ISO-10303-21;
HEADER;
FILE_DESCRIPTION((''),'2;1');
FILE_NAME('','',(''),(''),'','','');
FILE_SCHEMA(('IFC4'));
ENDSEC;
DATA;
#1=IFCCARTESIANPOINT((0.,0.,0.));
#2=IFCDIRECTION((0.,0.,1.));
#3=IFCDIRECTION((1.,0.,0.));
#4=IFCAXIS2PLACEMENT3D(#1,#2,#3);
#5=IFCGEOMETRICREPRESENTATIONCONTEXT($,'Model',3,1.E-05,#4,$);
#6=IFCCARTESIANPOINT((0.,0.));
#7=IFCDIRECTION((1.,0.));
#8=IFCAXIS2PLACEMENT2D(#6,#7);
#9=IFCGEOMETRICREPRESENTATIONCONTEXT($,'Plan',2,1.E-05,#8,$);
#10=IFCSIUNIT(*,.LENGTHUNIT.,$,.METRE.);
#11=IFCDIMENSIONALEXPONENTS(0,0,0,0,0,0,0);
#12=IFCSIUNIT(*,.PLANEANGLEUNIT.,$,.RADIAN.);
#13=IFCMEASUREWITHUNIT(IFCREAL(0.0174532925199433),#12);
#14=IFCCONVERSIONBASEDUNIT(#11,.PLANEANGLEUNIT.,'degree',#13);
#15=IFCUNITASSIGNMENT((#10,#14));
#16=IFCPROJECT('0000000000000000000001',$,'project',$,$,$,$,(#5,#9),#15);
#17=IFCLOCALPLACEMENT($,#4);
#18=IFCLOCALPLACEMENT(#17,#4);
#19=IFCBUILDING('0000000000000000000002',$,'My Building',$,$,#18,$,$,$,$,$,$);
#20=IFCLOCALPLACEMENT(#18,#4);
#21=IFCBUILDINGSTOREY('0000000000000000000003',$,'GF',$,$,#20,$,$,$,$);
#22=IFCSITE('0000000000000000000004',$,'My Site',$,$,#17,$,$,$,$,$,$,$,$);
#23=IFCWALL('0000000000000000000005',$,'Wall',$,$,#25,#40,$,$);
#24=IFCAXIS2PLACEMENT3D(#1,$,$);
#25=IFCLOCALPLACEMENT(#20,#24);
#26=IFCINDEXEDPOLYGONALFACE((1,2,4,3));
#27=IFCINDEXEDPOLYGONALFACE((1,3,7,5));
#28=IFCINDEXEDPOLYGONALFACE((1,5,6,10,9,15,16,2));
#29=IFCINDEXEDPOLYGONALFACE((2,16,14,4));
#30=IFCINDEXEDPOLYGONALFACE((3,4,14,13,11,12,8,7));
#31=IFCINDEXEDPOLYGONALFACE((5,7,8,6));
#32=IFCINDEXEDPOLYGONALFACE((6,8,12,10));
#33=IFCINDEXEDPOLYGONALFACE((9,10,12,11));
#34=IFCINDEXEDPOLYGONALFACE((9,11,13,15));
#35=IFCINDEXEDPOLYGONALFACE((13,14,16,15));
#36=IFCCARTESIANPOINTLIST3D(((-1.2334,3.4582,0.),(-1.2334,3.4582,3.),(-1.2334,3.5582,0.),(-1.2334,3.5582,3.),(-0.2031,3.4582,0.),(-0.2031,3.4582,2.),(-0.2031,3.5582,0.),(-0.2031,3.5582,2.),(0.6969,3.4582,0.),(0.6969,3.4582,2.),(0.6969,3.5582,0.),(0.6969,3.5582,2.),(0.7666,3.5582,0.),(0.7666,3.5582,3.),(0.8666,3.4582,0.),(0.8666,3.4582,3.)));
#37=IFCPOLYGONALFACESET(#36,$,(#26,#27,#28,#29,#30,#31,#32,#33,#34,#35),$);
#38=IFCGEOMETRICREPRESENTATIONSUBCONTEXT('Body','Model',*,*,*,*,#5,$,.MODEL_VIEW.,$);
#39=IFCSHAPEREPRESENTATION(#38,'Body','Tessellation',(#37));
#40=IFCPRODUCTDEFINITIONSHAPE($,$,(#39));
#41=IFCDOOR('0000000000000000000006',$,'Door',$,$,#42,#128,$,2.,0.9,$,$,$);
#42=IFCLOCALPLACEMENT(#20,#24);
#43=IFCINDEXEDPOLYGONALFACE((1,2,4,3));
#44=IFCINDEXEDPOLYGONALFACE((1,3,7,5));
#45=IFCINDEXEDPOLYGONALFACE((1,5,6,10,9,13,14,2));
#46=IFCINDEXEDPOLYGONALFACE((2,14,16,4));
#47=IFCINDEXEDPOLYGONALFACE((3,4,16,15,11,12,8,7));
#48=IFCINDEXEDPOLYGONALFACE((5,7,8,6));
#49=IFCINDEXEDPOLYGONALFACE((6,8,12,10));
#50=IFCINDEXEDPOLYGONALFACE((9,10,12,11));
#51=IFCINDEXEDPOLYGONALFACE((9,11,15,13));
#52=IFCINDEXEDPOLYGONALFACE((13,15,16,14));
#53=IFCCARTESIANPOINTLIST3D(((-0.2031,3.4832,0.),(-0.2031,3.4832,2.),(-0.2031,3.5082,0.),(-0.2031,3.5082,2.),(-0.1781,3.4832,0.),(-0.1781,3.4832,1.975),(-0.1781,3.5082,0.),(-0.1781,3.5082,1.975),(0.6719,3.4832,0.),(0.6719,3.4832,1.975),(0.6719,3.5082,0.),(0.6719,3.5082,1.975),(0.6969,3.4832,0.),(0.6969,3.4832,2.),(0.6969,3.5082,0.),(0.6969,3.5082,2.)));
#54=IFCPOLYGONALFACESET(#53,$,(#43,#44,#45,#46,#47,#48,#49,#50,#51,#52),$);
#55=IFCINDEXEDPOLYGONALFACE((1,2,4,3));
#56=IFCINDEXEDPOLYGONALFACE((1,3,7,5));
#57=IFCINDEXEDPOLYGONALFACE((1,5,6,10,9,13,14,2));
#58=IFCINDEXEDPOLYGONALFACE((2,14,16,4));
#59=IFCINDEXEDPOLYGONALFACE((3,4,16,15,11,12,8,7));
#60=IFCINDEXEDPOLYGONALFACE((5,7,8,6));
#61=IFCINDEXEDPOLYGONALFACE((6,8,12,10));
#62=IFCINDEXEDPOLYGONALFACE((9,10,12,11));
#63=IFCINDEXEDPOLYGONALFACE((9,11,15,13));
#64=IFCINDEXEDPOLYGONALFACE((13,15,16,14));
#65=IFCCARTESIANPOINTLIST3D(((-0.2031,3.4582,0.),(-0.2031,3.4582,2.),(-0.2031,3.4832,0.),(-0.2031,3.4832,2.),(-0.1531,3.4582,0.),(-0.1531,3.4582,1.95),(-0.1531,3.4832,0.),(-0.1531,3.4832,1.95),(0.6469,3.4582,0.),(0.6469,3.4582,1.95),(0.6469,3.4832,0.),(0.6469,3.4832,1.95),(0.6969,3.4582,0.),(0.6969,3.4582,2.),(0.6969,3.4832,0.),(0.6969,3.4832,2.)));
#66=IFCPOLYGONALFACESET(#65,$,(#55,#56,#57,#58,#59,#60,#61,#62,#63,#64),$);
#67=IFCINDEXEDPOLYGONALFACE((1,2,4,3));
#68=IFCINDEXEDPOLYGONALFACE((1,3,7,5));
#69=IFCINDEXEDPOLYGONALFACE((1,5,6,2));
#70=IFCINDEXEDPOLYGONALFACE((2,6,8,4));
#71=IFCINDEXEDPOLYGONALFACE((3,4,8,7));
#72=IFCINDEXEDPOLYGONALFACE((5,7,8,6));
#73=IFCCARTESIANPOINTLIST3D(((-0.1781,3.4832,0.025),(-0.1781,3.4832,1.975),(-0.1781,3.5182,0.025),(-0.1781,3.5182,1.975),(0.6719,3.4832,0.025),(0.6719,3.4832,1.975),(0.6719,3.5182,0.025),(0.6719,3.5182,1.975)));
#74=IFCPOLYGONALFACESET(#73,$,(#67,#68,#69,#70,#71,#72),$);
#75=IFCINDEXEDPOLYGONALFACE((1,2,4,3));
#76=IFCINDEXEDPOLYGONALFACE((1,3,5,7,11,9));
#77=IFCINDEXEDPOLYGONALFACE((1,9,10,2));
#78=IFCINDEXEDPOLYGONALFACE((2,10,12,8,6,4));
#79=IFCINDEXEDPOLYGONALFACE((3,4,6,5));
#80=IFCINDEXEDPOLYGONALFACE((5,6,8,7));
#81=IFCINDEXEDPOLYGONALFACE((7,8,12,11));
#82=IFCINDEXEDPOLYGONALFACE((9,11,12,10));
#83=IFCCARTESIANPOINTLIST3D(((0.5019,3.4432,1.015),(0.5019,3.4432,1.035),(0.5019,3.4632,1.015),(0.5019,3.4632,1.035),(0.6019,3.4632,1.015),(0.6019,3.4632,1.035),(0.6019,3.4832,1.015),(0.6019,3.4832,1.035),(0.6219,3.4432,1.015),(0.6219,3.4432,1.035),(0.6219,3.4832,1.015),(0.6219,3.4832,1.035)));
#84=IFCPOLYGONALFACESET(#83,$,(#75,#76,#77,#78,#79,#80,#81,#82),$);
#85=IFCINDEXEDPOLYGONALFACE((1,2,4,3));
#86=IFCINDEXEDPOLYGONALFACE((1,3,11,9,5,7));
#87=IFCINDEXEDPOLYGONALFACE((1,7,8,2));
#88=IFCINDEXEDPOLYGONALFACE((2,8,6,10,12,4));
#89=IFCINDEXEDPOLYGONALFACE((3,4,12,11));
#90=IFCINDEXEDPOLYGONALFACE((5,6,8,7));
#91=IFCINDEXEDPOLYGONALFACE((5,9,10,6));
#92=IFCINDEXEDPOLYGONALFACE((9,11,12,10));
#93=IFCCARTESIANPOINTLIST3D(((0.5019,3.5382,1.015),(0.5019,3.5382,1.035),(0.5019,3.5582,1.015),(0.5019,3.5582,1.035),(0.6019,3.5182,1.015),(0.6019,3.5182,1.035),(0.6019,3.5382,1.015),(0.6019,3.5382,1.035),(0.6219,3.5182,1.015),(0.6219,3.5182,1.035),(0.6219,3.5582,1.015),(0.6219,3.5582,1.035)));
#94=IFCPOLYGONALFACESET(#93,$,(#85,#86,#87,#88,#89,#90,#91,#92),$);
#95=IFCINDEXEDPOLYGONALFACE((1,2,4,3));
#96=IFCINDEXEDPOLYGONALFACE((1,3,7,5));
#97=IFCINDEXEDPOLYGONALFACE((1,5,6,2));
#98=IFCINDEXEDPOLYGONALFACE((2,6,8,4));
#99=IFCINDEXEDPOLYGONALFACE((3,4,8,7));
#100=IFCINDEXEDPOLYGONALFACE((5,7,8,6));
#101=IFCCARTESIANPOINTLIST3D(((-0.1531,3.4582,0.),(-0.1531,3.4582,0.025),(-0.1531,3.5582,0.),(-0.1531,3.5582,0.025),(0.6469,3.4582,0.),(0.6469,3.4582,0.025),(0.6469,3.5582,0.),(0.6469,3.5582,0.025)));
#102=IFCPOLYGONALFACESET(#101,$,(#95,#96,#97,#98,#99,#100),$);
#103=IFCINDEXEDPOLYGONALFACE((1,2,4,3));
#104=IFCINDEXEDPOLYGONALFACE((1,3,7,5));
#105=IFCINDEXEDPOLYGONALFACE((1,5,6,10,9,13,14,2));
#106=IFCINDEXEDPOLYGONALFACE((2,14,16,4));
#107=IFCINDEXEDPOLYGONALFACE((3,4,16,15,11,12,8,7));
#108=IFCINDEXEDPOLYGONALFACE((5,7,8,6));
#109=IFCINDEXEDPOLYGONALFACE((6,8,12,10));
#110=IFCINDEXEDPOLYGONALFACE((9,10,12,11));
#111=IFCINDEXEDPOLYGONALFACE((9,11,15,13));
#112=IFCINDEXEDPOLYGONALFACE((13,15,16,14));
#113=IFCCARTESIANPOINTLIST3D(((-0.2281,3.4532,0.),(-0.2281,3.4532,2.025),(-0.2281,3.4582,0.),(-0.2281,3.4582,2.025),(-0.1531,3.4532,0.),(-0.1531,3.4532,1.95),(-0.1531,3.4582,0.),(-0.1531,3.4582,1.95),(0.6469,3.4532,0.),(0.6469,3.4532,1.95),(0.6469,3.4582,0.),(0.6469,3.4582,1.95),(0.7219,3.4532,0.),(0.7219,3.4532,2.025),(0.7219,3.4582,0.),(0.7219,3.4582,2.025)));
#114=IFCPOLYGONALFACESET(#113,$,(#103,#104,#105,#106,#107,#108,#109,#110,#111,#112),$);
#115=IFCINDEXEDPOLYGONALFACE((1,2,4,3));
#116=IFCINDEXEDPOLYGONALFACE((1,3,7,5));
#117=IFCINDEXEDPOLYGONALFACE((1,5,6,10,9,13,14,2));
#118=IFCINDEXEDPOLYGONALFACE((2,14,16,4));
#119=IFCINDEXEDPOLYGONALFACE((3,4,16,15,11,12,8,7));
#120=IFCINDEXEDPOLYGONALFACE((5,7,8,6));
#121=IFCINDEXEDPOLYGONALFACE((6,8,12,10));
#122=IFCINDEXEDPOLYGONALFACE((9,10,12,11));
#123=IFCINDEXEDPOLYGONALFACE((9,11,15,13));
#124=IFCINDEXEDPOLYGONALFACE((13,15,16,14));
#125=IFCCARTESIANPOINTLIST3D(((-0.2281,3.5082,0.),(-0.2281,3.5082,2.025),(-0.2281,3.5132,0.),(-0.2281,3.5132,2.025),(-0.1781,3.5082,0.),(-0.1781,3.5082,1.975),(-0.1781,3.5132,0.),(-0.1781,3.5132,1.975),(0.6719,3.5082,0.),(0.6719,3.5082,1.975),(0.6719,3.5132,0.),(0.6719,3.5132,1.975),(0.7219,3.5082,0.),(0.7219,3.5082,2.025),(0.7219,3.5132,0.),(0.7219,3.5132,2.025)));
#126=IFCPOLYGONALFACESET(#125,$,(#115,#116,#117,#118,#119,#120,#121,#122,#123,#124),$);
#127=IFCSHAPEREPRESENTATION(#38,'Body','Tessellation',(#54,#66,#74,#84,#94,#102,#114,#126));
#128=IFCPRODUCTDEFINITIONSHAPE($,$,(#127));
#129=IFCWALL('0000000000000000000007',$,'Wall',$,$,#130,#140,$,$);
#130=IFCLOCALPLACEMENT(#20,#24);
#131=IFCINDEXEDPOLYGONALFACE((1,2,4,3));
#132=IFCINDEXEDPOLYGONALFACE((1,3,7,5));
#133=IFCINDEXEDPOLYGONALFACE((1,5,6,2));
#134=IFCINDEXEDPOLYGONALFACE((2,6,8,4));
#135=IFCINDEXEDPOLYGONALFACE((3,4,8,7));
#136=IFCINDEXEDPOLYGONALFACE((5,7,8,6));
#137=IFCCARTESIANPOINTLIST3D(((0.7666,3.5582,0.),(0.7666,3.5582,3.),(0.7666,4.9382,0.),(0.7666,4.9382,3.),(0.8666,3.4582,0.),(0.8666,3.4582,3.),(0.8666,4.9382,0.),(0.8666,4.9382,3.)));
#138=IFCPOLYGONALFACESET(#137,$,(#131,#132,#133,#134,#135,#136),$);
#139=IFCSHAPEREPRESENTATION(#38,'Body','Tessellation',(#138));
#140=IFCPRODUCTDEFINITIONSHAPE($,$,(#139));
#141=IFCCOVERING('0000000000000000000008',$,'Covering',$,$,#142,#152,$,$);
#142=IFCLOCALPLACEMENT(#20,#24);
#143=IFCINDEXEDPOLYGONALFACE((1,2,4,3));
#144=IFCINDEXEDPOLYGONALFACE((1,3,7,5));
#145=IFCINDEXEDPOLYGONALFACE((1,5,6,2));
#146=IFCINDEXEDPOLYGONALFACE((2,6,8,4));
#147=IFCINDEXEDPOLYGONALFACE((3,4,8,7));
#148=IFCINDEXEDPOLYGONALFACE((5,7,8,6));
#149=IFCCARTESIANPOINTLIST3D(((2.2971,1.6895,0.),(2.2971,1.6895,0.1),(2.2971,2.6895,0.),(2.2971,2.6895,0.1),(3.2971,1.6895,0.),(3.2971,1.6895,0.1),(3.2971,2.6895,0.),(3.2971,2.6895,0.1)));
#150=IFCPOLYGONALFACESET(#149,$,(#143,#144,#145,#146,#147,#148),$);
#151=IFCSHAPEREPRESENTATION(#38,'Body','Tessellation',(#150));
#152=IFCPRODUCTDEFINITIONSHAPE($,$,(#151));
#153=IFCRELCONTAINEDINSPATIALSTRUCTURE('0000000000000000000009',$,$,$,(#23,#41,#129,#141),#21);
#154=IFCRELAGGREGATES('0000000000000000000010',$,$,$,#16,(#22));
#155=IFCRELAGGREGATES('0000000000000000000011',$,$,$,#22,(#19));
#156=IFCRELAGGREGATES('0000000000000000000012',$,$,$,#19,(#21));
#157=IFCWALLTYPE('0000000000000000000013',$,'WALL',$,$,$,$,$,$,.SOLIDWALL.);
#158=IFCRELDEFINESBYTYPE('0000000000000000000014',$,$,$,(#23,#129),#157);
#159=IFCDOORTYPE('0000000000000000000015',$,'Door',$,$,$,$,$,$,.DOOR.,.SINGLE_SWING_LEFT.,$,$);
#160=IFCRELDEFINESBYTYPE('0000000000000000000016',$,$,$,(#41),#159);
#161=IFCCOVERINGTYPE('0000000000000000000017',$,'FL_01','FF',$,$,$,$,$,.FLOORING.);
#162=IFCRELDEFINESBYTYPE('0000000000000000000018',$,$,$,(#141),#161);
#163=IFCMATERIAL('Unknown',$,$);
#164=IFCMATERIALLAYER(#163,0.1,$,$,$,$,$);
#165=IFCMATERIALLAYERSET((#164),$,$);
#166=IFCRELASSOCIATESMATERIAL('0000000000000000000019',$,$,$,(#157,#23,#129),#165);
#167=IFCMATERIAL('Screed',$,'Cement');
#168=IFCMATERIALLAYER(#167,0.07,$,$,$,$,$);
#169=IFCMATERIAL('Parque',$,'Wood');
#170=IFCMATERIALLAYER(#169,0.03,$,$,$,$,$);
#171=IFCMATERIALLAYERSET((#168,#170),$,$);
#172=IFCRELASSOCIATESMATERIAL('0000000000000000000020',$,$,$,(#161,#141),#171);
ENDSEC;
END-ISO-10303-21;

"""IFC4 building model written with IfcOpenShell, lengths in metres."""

from ifc_helpers import new_model, entity, si_unit, converted_unit, frame, origin_with_axes, origin_2d_with_axis, place, context, subcontext, project, spatial, line, indexed_curve, outline, extrude, shape, source, transform, mapped, material, layer, layer_set, layer_usage, type_object, type_shapes, element, fill, save


model = new_model("IFC4")

# Units and contexts
model_context = context("Model", 3, precision=1e-05, world=origin_with_axes())
plan_context = context("Plan", 2, precision=1e-05, world=origin_2d_with_axis())
body_context_1 = subcontext(model_context, "Body", "Model", "MODEL_VIEW")
body_context_2 = subcontext(plan_context, "Body", "Plan", "PLAN_VIEW")
ifc_project = project(units=[si_unit("LENGTHUNIT", "METRE"), converted_unit("PLANEANGLEUNIT", "degree", entity("IfcReal", 0.0174532925199433), si_unit("PLANEANGLEUNIT", "RADIAN"), dimensions=[0, 0, 0, 0, 0, 0, 0])], contexts=[model_context, plan_context])

# Site, building, storey
site_placement = place(None, origin_with_axes())
site = spatial("IfcSite", under=ifc_project, at=site_placement, Name="My Site")
building_placement = place(site_placement, origin_with_axes())
building = spatial("IfcBuilding", under=site, at=building_placement, Name="My Building")
storey_placement = place(building_placement, origin_with_axes())
storey = spatial("IfcBuildingStorey", under=building, at=storey_placement, Name="GF")

# Shared definitions
ifc_material_1 = material(Name="Unknown")

# Shared definitions
ifc_layer_1 = layer(ifc_material_1, 0.1)
ifc_layer_set_1 = layer_set([ifc_layer_1])
wall_type = type_object("IfcWallType", Name="WALL", PredefinedType="SOLIDWALL", material=ifc_layer_set_1)
shared_shape_1 = source(origin_with_axes(), body_context_1, "Body", "SweptSolid", [
    extrude(outline(indexed_curve([(0.0, 0.0), (0.9, 0.0), (0.9, 2.0), (0.0, 2.0)], segments=[line(1, 2, 3, 4, 1)])), frame((0.0, -0.6, 0.0), z_axis=(0.0, -1.0, 0.0), x_axis=(1.0, 0.0, 0.0)), (0.0, 0.0, -1.0), 1.2),
])
door_type = type_object("IfcDoorType", Name="Door", OperationType="SINGLE_SWING_LEFT", PredefinedType="DOOR")
shared_shape_2 = source(origin_with_axes(), body_context_1, "Body", "SweptSolid", [
    extrude(outline(indexed_curve([(0.0, 0.0), (0.0, 2.0), (0.9, 2.0), (0.9, 0.0), (0.875, 0.0), (0.875, 1.975), (0.025, 1.975), (0.025, 0.0)], segments=[line(1, 2, 3, 4, 5, 6, 7, 8, 1)])), frame((0.0, 0.025, 0.0), z_axis=(0.0, -1.0, 0.0), x_axis=(1.0, 0.0, 0.0)), (0.0, 0.0, -1.0), 0.025),
    extrude(outline(indexed_curve([(0.0, 0.0), (0.0, 2.0), (0.9, 2.0), (0.9, 0.0), (0.85, 0.0), (0.85, 1.95), (0.05, 1.95), (0.05, 0.0)], segments=[line(1, 2, 3, 4, 5, 6, 7, 8, 1)])), frame((0.0, 0.0, 0.0), z_axis=(0.0, -1.0, 0.0), x_axis=(1.0, 0.0, 0.0)), (0.0, 0.0, -1.0), 0.025),
    extrude(outline(indexed_curve([(0.0, 0.0), (0.85, 0.0), (0.85, 0.035), (0.0, 0.035)], segments=[line(1, 2, 3, 4, 1)])), frame((0.025, 0.025, 0.025), z_axis=(0.0, 0.0, 1.0), x_axis=(1.0, 0.0, 0.0)), (0.0, 0.0, 1.0), 1.95),
    extrude(outline(indexed_curve([(0.0, 0.0), (0.0, -0.04), (-0.12, -0.04), (-0.12, -0.02), (-0.02, -0.02), (-0.02, 0.0)], segments=[line(1, 2, 3, 4, 5, 6, 1)])), frame((0.825, 0.025, 1.015), z_axis=(0.0, 0.0, 1.0), x_axis=(1.0, 0.0, 0.0)), (0.0, 0.0, 1.0), 0.02),
    extrude(outline(indexed_curve([(0.0, 0.0), (0.0, 0.04), (-0.12, 0.04), (-0.12, 0.02), (-0.02, 0.02), (-0.02, 0.0)], segments=[line(1, 2, 3, 4, 5, 6, 1)])), frame((0.825, 0.06, 1.015), z_axis=(0.0, 0.0, 1.0), x_axis=(1.0, 0.0, 0.0)), (0.0, 0.0, 1.0), 0.02),
    extrude(outline(indexed_curve([(0.0, 0.0), (0.8, 0.0), (0.8, 0.1), (0.0, 0.1)], segments=[line(1, 2, 3, 4, 1)])), frame((0.05, 0.0, 0.0), z_axis=(0.0, 0.0, 1.0), x_axis=(1.0, 0.0, 0.0)), (0.0, 0.0, 1.0), 0.025),
    extrude(outline(indexed_curve([(0.0, 0.0), (0.0, 2.025), (0.95, 2.025), (0.95, 0.0), (0.875, 0.0), (0.875, 1.95), (0.075, 1.95), (0.075, 0.0)], segments=[line(1, 2, 3, 4, 5, 6, 7, 8, 1)])), frame((-0.025, -0.005, 0.0), z_axis=(0.0, -1.0, 0.0), x_axis=(1.0, 0.0, 0.0)), (0.0, 0.0, -1.0), 0.005),
    extrude(outline(indexed_curve([(0.0, 0.0), (0.0, 2.025), (0.95, 2.025), (0.95, 0.0), (0.9, 0.0), (0.9, 1.975), (0.05, 1.975), (0.05, 0.0)], segments=[line(1, 2, 3, 4, 5, 6, 7, 8, 1)])), frame((-0.025, 0.05, 0.0), z_axis=(0.0, -1.0, 0.0), x_axis=(1.0, 0.0, 0.0)), (0.0, 0.0, -1.0), 0.005),
])
shared_shape_3 = source(origin_with_axes(), body_context_2, "Body", "Curve2D", [
    entity("IfcIndexedPolyCurve", entity("IfcCartesianPointList2D", [[0.0, 0.0], [0.0, 0.05], [0.025, 0.05], [0.025, 0.025], [0.05, 0.025], [0.05, 0.0]]), [entity("IfcLineIndex", [1, 2, 3, 4, 5, 6, 1])]),
    entity("IfcIndexedPolyCurve", entity("IfcCartesianPointList2D", [[0.9, 0.0], [0.9, 0.05], [0.875, 0.05], [0.875, 0.025], [0.85, 0.025], [0.85, 0.0]]), [entity("IfcLineIndex", [1, 2, 3, 4, 5, 6, 1])]),
    entity("IfcTrimmedCurve", entity("IfcEllipse", entity("IfcAxis2Placement2D", entity("IfcCartesianPoint", [0.06, 0.05]), entity("IfcDirection", [1.0, 0.0])), 0.815, 0.85), [entity("IfcCartesianPoint", [0.875, 0.05])], [entity("IfcCartesianPoint", [0.06, 0.9])], True, "CARTESIAN"),
    entity("IfcIndexedPolyCurve", entity("IfcCartesianPointList2D", [[0.025, 0.05], [0.06, 0.05], [0.06, 0.9], [0.025, 0.9]]), [entity("IfcLineIndex", [1, 2, 3, 4, 1])]),
])
type_shapes(door_type, [shared_shape_2, shared_shape_3])

# Wall, opening, door
ifc_layer_usage_1 = layer_usage(ifc_layer_set_1, "AXIS2", "POSITIVE", 0.0)
wall_1_placement = place(storey_placement, frame((-1.2334, 3.4582, 0.0), z_axis=(0.0, 0.0, 1.0), x_axis=(1.0, 0.0, 0.0)))
wall_1 = element("IfcWall", 1, at=wall_1_placement, inside=storey, type_object=wall_type, material=ifc_layer_usage_1, Name="Wall", context=body_context_1, shape_type="SweptSolid", body=[
    extrude(outline(indexed_curve([(0.0, 0.0), (0.0, 0.1), (2.0, 0.1), (2.1, 0.0)], segments=[line(1, 2, 3, 4, 1)])), origin_with_axes(), (0.0, 0.0, 1.0), 3.0),
])
opening_1_placement = place(wall_1_placement, frame((1.0303, 0.0, 0.0), z_axis=(0.0, 0.0, 1.0), x_axis=(1.0, 0.0, 0.0)))
opening_1 = element("IfcOpeningElement", 2, at=opening_1_placement, cuts=wall_1, PredefinedType="OPENING", context=body_context_1, shape_type="MappedRepresentation", body=[
    mapped(shared_shape_1, transform((0.0, 0.0, 0.0), x_axis=(1.0, 0.0, 0.0), y_axis=(0.0, 1.0, 0.0), z_axis=(0.0, 0.0, 1.0), scale=1.0)),
])
door_1_placement = place(opening_1_placement, origin_with_axes())
door_1 = element("IfcDoor", 3, at=door_1_placement, inside=storey, type_object=door_type, Name="Door", OverallHeight=2.0, OverallWidth=0.9, shapes=[
    shape(body_context_1, "Body", "MappedRepresentation", [mapped(shared_shape_2, transform((0.0, 0.0, 0.0), x_axis=(1.0, 0.0, 0.0), y_axis=(0.0, 1.0, 0.0), z_axis=(0.0, 0.0, 1.0), scale=1.0))]),
    shape(body_context_2, "Body", "MappedRepresentation", [mapped(shared_shape_3, transform((0.0, 0.0, 0.0), x_axis=(1.0, 0.0, 0.0), y_axis=(0.0, 1.0, 0.0), z_axis=(0.0, 0.0, 1.0), scale=1.0))]),
])
fill(opening_1, door_1)

# Wall
ifc_layer_usage_2 = layer_usage(ifc_layer_set_1, "AXIS2", "POSITIVE", 0.0)
wall_2_placement = place(storey_placement, frame((0.8666, 3.4582, 0.0), z_axis=(0.0, 0.0, 1.0), x_axis=(0.0, 1.0, 0.0)))
element("IfcWall", 4, at=wall_2_placement, inside=storey, type_object=wall_type, material=ifc_layer_usage_2, Name="Wall", context=body_context_1, shape_type="SweptSolid", body=[
    extrude(outline(indexed_curve([(0.0, 0.0), (0.1, 0.1), (1.48, 0.1), (1.48, 0.0)], segments=[line(1, 2, 3, 4, 1)])), origin_with_axes(), (0.0, 0.0, 1.0), 3.0),
])

# Covering
ifc_material_2 = material(Name="Screed", Category="Cement")
ifc_layer_2 = layer(ifc_material_2, 0.07)
ifc_material_3 = material(Name="Parque", Category="Wood")
ifc_layer_3 = layer(ifc_material_3, 0.03)
ifc_layer_set_2 = layer_set([ifc_layer_2, ifc_layer_3])
ifc_layer_usage_3 = layer_usage(ifc_layer_set_2, "AXIS3", "POSITIVE", 0.0)
covering_type = type_object("IfcCoveringType", Name="FL_01", Description="FF", PredefinedType="FLOORING", material=ifc_layer_set_2)
covering_placement = place(storey_placement, frame((2.2971, 1.6895, 0.0), z_axis=(0.0, 0.0, 1.0), x_axis=(1.0, 0.0, 0.0)))
element("IfcCovering", 5, at=covering_placement, inside=storey, type_object=covering_type, material=ifc_layer_usage_3, Name="Covering", context=body_context_1, shape_type="SweptSolid", body=[
    extrude(outline(indexed_curve([(0.0, 0.0), (1.0, 0.0), (1.0, 1.0), (0.0, 1.0), (0.0, 0.0)])), None, (0.0, 0.0, 1.0), 0.1),
])

save(model, "model.ifc")
